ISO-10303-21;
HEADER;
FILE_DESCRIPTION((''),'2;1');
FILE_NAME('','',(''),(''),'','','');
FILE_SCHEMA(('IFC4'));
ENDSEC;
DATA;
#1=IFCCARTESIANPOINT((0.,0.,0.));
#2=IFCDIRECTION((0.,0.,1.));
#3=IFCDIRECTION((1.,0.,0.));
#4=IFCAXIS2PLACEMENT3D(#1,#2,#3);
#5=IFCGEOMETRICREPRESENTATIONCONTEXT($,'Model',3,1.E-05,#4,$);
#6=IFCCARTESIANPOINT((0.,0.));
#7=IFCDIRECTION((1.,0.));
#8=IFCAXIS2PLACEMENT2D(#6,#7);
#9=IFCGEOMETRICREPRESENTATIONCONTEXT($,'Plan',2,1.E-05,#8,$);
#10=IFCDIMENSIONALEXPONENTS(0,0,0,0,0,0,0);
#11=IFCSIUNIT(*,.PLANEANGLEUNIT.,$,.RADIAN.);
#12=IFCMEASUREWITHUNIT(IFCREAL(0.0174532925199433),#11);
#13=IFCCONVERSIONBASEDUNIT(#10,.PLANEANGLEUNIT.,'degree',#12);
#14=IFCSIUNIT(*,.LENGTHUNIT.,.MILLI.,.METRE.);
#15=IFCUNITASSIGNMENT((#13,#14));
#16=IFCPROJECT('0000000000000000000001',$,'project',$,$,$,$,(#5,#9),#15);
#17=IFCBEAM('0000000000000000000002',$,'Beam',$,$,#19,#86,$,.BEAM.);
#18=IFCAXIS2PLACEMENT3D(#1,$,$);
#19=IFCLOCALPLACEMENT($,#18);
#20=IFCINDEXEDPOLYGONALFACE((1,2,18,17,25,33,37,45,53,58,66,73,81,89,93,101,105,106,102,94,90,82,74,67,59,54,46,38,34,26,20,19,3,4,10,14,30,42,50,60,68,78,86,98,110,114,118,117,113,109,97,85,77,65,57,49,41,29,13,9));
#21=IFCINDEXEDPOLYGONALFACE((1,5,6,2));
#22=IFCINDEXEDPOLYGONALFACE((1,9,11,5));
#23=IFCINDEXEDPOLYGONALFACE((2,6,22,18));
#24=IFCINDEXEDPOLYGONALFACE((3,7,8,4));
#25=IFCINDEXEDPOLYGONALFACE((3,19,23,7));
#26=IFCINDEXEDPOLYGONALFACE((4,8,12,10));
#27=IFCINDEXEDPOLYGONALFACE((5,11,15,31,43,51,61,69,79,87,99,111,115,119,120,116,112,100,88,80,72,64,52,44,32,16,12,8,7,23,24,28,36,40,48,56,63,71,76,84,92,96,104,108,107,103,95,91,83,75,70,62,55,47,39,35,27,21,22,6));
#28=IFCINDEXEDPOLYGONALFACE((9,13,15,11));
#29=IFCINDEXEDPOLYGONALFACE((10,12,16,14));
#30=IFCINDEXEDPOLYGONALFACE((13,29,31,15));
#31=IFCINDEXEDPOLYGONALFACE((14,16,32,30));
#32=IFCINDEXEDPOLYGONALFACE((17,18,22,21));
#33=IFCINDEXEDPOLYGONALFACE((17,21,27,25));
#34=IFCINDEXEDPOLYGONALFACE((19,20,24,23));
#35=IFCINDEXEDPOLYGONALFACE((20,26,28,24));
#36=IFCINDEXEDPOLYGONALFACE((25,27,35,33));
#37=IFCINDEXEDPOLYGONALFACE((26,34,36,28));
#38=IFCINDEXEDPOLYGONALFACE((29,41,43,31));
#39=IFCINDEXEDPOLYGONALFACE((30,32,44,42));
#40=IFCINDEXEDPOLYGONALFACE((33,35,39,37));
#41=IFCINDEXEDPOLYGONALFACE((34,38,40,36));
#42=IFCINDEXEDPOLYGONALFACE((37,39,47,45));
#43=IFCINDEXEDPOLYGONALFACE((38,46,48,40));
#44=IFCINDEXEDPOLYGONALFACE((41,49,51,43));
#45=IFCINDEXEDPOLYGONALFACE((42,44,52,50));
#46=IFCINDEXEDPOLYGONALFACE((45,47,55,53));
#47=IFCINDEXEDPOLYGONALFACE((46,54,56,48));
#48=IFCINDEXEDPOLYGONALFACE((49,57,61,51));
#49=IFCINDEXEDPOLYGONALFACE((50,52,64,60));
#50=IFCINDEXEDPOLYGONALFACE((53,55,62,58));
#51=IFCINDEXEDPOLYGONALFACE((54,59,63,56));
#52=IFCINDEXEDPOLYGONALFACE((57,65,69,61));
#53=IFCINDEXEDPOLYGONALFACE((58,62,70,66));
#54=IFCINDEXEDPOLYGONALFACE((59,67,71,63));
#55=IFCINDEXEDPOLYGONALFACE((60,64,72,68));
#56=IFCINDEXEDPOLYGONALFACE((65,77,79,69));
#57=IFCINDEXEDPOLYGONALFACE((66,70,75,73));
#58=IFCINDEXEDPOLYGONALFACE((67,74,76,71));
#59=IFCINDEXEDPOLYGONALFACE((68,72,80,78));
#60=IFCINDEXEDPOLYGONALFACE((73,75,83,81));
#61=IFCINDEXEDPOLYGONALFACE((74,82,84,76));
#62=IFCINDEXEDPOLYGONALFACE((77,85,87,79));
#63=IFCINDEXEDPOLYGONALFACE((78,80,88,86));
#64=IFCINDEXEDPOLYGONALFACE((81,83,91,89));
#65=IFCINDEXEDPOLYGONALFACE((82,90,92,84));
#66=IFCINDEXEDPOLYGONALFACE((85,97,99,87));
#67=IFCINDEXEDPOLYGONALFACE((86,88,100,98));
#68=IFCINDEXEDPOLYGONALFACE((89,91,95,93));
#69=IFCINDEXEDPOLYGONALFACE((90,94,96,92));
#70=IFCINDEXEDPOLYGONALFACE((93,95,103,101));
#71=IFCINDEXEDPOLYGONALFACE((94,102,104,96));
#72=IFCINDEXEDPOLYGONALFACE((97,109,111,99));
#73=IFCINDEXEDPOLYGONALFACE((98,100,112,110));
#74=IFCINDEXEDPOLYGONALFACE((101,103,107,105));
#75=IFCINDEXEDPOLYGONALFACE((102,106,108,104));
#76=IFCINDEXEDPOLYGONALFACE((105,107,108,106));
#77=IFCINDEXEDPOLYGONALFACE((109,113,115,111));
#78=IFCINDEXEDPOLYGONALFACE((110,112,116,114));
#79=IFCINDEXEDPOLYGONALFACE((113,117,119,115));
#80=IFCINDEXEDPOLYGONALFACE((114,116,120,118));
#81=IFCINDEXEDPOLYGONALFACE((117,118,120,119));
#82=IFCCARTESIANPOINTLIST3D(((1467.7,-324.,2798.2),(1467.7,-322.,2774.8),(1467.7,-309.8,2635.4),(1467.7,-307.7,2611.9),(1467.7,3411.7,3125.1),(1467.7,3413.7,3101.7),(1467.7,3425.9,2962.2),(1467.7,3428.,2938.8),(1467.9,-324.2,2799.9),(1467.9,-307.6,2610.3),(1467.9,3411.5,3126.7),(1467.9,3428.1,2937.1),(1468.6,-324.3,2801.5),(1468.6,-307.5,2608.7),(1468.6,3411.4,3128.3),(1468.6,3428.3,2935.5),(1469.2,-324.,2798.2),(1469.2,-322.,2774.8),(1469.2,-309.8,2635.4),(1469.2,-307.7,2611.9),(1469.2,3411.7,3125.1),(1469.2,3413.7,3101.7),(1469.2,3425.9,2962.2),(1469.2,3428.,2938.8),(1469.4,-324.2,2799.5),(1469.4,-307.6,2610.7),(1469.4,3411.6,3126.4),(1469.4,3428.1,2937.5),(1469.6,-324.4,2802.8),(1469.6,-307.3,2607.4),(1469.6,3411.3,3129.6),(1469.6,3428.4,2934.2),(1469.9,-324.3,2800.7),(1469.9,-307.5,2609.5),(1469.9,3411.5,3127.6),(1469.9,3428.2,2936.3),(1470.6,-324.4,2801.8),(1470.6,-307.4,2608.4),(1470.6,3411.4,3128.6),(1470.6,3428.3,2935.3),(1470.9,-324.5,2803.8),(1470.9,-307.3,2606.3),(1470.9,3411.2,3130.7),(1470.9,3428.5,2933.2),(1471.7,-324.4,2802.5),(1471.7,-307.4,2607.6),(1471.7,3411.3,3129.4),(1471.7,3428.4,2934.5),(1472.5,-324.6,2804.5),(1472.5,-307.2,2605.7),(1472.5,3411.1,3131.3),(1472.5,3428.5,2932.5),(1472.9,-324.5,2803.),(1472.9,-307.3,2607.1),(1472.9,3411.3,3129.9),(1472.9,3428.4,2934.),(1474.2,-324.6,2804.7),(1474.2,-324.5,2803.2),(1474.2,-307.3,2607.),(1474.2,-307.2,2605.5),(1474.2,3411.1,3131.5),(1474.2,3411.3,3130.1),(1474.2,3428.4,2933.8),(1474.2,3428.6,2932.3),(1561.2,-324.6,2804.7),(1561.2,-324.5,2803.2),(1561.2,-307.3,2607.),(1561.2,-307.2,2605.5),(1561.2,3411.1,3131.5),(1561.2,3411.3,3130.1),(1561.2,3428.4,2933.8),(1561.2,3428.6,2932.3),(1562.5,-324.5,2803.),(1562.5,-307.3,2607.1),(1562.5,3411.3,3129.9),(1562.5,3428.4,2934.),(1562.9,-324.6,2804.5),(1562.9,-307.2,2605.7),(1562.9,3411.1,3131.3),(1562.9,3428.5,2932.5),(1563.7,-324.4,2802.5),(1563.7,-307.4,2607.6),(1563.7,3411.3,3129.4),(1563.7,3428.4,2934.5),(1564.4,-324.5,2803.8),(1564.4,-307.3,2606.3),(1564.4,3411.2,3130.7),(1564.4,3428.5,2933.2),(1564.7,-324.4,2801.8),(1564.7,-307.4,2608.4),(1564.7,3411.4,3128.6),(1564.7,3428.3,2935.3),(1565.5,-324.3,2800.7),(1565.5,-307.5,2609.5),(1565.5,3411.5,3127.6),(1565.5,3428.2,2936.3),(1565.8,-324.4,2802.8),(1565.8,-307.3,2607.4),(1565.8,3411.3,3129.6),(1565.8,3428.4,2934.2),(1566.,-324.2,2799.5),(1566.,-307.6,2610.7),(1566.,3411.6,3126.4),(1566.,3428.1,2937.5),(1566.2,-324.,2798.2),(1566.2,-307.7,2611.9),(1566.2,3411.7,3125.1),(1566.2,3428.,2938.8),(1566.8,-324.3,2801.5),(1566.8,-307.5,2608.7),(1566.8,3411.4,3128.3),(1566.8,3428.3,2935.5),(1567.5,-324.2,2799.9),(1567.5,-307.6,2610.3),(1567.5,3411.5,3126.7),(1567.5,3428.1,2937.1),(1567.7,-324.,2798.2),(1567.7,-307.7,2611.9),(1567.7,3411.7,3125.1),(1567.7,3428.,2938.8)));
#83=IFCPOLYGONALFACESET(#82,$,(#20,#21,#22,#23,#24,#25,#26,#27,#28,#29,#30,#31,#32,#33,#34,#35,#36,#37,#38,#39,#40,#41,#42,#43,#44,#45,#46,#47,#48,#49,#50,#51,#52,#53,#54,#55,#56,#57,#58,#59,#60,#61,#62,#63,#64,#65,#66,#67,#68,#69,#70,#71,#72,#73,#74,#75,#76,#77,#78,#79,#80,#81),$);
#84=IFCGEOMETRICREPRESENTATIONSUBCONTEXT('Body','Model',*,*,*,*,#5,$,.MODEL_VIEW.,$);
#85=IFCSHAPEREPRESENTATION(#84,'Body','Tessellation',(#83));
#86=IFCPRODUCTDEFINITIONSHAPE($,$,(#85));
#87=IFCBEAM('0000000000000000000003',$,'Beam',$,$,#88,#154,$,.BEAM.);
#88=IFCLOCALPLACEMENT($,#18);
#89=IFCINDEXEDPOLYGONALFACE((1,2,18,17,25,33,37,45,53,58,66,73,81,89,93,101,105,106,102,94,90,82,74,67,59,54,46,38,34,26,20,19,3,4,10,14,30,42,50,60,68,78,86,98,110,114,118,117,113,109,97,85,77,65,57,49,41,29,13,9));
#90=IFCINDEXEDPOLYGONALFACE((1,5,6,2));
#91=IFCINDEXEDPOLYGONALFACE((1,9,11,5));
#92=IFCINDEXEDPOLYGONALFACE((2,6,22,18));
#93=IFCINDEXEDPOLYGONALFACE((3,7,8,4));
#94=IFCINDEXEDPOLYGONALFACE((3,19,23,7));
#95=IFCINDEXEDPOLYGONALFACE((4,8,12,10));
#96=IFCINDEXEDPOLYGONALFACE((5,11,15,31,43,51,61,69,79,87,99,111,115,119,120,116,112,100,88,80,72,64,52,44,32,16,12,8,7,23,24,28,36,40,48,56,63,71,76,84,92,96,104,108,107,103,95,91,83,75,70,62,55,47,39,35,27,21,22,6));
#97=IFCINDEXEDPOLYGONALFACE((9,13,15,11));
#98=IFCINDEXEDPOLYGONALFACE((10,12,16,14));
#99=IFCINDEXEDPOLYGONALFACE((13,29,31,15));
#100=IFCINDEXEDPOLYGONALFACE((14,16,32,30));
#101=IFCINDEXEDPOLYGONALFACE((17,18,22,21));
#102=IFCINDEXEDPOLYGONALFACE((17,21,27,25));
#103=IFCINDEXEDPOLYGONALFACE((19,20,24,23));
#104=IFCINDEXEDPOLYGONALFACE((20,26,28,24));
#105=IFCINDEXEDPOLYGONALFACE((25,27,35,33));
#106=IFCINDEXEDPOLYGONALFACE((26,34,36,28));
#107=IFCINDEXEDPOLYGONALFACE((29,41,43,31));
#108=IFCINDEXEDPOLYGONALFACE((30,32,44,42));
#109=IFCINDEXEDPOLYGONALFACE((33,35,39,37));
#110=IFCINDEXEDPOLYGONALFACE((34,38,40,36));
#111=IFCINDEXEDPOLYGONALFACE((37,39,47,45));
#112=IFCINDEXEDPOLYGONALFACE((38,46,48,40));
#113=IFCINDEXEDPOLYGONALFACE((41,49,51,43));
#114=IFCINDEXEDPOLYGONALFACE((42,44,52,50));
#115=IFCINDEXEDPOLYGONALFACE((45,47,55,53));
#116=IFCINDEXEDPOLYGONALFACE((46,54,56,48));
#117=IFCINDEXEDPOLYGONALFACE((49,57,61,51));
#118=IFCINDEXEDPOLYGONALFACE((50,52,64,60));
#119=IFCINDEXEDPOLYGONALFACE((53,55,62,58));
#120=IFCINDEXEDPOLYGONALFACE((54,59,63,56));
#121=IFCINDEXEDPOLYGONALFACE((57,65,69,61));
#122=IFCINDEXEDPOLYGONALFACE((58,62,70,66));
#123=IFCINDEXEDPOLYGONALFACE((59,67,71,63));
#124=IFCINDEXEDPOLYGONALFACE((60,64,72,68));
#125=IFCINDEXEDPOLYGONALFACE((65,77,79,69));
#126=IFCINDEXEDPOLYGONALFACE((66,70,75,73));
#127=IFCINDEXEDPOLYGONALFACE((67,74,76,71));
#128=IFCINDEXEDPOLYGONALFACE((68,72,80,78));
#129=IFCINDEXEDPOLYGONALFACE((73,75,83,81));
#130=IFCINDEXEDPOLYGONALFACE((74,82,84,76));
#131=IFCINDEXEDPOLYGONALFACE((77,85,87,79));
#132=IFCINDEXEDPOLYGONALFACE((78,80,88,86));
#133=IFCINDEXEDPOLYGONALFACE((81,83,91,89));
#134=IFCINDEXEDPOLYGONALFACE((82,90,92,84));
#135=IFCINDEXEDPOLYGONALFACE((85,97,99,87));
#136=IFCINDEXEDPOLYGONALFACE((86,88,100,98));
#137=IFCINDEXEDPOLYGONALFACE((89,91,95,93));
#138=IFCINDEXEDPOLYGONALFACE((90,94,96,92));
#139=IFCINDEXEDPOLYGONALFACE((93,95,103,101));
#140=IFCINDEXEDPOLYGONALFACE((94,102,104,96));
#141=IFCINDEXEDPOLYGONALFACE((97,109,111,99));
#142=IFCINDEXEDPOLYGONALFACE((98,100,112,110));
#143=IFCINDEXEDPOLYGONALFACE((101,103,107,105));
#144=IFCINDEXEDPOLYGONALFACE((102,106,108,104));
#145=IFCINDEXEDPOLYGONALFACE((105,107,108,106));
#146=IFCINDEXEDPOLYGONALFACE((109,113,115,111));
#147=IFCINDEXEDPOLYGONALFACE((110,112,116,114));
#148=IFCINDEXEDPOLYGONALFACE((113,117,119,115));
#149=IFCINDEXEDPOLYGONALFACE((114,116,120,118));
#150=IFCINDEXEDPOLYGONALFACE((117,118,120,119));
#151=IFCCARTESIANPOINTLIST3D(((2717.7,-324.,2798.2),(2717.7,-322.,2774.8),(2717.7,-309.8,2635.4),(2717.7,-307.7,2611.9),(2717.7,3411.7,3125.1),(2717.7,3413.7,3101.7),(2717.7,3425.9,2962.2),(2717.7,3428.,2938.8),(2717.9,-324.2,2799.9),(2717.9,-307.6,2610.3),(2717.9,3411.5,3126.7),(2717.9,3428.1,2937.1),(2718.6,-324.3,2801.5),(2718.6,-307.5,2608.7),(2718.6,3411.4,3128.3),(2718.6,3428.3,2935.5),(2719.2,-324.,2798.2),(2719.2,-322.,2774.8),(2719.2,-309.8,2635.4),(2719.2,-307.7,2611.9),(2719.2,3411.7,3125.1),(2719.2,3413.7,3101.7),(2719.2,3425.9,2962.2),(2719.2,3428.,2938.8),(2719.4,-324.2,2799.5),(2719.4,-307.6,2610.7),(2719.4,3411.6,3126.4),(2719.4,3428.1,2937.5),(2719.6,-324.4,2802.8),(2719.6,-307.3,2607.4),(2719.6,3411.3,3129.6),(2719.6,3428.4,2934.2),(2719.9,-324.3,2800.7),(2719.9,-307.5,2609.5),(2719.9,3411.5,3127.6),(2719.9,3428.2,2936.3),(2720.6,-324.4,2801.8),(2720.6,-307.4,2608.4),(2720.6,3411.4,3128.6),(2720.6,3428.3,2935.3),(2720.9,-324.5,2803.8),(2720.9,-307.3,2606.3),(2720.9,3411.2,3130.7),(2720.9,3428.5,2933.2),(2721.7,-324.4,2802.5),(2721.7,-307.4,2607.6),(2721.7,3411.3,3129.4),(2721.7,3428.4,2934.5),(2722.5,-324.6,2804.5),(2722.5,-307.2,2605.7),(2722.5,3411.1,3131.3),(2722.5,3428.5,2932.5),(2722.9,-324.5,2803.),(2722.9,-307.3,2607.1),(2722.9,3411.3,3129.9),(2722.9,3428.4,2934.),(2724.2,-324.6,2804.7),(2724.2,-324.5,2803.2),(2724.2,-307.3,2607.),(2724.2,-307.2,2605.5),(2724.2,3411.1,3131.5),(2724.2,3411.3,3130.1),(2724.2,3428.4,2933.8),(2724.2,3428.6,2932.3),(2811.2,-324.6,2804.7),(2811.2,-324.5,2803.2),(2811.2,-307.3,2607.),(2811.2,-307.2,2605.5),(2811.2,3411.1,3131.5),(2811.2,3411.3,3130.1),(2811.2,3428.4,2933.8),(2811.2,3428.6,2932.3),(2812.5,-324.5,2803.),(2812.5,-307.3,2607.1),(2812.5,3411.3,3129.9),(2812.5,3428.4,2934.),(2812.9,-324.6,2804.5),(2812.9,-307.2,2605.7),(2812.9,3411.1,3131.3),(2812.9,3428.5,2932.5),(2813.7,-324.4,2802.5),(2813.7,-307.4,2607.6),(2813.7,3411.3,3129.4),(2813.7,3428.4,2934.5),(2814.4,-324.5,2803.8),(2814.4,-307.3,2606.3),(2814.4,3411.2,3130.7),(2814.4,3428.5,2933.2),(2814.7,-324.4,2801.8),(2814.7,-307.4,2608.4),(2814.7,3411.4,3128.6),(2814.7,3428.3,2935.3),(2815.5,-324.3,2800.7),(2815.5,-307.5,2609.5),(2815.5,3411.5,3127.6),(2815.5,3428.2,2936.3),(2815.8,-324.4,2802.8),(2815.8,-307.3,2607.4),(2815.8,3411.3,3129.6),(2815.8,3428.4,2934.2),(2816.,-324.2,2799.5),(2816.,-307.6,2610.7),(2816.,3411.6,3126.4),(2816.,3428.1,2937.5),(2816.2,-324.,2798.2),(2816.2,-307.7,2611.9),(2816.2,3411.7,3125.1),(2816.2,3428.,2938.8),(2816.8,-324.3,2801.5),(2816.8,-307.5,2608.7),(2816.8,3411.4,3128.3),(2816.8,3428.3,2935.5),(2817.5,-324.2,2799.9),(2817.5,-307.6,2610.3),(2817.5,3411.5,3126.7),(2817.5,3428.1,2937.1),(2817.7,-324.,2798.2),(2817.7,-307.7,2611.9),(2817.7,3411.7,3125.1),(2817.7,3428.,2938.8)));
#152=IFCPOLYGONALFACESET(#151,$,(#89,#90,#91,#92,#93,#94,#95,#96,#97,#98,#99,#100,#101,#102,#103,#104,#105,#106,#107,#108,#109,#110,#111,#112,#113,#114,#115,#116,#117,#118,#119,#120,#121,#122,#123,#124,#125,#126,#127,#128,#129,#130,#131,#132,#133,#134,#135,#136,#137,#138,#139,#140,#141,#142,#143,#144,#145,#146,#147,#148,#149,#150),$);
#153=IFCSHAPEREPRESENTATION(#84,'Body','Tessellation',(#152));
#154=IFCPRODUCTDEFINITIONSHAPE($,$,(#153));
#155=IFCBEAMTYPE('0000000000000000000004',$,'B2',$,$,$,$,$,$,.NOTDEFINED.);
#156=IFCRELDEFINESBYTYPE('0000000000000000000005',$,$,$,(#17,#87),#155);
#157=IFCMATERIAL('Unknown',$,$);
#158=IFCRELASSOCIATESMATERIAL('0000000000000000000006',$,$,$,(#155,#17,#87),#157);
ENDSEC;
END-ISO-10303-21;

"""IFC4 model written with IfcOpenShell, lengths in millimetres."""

from ifc_helpers import new_model, entity, si_unit, converted_unit, frame, origin_with_axes, origin_2d_with_axis, place, context, subcontext, project, c_section, extrude, material, material_profile, profile_set, profile_usage, type_object, element, save


model = new_model("IFC4")

# Units and contexts
model_context = context("Model", 3, precision=1e-05, world=origin_with_axes())
plan_context = context("Plan", 2, precision=1e-05, world=origin_2d_with_axis())
body_context = subcontext(model_context, "Body", "Model", "MODEL_VIEW")
ifc_project = project(units=[converted_unit("PLANEANGLEUNIT", "degree", entity("IfcReal", 0.0174532925199433), si_unit("PLANEANGLEUNIT", "RADIAN"), dimensions=[0, 0, 0, 0, 0, 0, 0]), si_unit("LENGTHUNIT", "METRE", prefix="MILLI")], contexts=[model_context, plan_context])

# Shared definitions
ifc_material = material(Name="Unknown")

# Beams
ifc_material_profile_1 = material_profile(ifc_material, c_section(Depth=200.0, Width=100.0, WallThickness=1.5, Girth=30.0, InternalFilletRadius=5.0))
ifc_profile_set_1 = profile_set([ifc_material_profile_1])
beam_type_1 = type_object("IfcBeamType", Name="B2", PredefinedType="NOTDEFINED", material=ifc_profile_set_1)
ifc_profile_usage_1 = profile_usage(ifc_profile_set_1, cardinal=5)
beam_1_placement = place(None, frame((1517.7, -315.9, 2705.1), z_axis=(0.0, 0.996195, 0.087155), x_axis=(-1.0, 0.0, 0.0)))
element("IfcBeam", 1, at=beam_1_placement, type_object=beam_type_1, material=ifc_profile_usage_1, Name="Beam", PredefinedType="BEAM", context=body_context, shape_type="SweptSolid", body=[
    extrude(c_section(Depth=200.0, Width=100.0, WallThickness=1.5, Girth=30.0, InternalFilletRadius=5.0), origin_with_axes(), (0.0, 0.0, 1.0), 3750.0),
])
ifc_profile_usage_2 = profile_usage(ifc_profile_set_1, cardinal=5)
beam_2_placement = place(None, frame((2767.7, -315.9, 2705.1), z_axis=(0.0, 0.996195, 0.087155), x_axis=(-1.0, 0.0, 0.0)))
element("IfcBeam", 2, at=beam_2_placement, type_object=beam_type_1, material=ifc_profile_usage_2, Name="Beam", PredefinedType="BEAM", context=body_context, shape_type="SweptSolid", body=[
    extrude(c_section(Depth=200.0, Width=100.0, WallThickness=1.5, Girth=30.0, InternalFilletRadius=5.0), origin_with_axes(), (0.0, 0.0, 1.0), 3750.0),
])

save(model, "model.ifc")
